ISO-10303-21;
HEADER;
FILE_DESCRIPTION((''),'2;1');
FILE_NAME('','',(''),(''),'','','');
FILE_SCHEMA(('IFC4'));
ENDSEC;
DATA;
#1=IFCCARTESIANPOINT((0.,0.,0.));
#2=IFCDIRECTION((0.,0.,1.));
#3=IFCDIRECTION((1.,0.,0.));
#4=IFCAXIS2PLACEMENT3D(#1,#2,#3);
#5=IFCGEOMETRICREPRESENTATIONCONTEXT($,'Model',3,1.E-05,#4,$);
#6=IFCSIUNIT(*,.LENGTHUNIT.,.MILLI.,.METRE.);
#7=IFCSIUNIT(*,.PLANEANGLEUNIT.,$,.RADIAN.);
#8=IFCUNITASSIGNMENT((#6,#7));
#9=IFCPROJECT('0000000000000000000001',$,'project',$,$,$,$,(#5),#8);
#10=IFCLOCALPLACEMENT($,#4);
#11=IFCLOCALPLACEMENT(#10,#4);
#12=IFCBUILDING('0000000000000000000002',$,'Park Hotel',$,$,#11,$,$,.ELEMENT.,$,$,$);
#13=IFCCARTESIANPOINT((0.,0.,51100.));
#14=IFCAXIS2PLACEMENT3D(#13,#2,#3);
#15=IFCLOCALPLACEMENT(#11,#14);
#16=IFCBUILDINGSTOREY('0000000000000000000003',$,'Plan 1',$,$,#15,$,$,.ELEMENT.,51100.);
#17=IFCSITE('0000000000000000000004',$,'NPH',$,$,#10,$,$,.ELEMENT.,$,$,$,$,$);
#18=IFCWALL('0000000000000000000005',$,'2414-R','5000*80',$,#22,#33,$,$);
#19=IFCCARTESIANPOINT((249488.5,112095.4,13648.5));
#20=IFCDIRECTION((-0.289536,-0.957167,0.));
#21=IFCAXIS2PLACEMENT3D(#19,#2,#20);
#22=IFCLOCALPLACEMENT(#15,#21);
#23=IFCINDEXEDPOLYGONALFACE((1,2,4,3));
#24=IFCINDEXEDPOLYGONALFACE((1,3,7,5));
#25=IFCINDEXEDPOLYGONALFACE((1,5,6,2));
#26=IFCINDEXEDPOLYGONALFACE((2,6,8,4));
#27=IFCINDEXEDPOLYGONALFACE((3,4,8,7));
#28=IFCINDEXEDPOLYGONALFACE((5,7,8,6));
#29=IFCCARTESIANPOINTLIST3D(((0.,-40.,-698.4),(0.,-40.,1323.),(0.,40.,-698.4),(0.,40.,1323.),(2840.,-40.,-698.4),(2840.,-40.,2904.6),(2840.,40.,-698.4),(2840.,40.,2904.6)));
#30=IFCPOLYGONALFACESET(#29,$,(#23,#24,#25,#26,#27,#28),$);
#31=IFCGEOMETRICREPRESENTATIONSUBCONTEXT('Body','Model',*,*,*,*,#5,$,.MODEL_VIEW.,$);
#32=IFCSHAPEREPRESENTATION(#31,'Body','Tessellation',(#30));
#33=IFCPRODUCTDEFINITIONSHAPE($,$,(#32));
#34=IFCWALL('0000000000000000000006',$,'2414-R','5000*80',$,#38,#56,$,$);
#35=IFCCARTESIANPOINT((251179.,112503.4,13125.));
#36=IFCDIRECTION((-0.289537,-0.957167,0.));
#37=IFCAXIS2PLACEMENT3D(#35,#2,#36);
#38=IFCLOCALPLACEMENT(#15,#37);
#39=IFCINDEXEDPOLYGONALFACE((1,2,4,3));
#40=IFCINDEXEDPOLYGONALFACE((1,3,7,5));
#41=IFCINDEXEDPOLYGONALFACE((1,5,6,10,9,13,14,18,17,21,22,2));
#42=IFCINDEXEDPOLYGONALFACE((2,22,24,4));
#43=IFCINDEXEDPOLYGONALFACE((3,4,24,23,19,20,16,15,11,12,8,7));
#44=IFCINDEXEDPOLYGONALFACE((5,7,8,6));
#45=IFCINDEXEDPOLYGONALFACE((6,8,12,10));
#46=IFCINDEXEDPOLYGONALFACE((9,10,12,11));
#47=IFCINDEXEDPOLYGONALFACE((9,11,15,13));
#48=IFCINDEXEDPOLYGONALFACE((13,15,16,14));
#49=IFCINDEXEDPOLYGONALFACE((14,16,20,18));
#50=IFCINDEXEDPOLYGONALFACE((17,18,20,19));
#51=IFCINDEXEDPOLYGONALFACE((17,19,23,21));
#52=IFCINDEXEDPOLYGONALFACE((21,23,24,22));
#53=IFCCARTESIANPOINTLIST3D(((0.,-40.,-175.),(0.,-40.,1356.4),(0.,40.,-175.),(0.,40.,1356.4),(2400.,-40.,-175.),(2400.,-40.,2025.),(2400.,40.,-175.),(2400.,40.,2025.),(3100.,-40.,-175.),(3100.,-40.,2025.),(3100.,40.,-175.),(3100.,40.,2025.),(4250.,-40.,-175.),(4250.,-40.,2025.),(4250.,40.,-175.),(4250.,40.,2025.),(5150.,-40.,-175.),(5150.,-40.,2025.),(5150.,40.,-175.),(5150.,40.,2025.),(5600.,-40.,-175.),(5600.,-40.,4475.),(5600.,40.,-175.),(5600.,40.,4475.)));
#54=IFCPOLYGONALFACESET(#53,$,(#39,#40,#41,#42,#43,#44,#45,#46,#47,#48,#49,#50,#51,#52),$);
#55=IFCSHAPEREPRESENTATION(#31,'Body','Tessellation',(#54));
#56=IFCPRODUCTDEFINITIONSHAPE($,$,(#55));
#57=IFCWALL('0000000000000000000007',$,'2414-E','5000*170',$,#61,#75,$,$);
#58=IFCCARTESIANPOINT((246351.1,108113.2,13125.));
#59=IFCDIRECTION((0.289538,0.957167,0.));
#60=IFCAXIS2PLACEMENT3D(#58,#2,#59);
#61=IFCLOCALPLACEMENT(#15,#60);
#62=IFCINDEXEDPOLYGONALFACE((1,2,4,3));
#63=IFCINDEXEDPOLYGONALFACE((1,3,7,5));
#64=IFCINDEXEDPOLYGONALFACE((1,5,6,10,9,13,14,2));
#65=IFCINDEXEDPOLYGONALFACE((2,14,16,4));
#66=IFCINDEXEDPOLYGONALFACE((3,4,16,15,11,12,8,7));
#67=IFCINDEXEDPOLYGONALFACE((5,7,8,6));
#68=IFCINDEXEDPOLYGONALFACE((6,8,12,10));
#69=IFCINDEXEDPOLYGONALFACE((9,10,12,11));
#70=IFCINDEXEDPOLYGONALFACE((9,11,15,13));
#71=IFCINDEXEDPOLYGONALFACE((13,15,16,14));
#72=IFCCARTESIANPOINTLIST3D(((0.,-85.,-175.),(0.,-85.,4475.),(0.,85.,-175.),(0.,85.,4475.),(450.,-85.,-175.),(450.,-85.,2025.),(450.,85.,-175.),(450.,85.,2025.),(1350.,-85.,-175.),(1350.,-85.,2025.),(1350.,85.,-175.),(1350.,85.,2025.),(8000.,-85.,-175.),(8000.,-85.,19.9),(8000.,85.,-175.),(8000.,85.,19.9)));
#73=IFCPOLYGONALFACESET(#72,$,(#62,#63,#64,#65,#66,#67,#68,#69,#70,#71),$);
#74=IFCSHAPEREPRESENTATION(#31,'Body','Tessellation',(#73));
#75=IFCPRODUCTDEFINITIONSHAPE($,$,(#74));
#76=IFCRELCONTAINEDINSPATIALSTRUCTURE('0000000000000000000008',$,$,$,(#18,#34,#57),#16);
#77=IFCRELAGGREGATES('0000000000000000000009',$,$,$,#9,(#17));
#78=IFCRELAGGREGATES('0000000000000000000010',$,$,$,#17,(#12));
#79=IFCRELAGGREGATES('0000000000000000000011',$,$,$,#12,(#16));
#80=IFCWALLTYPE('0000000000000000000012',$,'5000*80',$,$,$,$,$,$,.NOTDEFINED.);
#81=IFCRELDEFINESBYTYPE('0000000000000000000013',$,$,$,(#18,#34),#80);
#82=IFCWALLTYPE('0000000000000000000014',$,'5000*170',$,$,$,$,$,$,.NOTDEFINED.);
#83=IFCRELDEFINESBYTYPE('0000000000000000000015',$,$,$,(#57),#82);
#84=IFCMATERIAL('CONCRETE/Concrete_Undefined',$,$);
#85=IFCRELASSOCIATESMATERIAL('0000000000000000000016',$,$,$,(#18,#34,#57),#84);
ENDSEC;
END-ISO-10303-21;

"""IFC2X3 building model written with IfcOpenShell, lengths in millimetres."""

from ifc_helpers import new_model, si_unit, frame, frame_2d, origin_with_axes, place, context, subcontext, project, spatial, rectangle, extrude, boolean, clip, halfspace, material, type_object, element, save


model = new_model("IFC2X3")

# Units and contexts
model_context = context("Model", 3, precision=1e-05, world=origin_with_axes())
body_context = subcontext(model_context, "Body", "Model", "MODEL_VIEW")
ifc_project = project(units=[si_unit("LENGTHUNIT", "METRE", prefix="MILLI"), si_unit("PLANEANGLEUNIT", "RADIAN")], contexts=[model_context])

# Site, building, storey
site_placement = place(None, origin_with_axes())
site = spatial("IfcSite", under=ifc_project, at=site_placement, Name="NPH", CompositionType="ELEMENT")
building_placement = place(site_placement, origin_with_axes())
building = spatial("IfcBuilding", under=site, at=building_placement, Name="Park Hotel", CompositionType="ELEMENT")
storey_placement = place(building_placement, frame((0.0, 0.0, 51100.0), z_axis=(0.0, 0.0, 1.0), x_axis=(1.0, 0.0, 0.0)))
storey = spatial("IfcBuildingStorey", under=building, at=storey_placement, Name="Plan 1", CompositionType="ELEMENT", Elevation=51100.0)

# Walls
ifc_material_1 = material(Name="CONCRETE/Concrete_Undefined")
wall_type_1 = type_object("IfcWallType", Name="5000*80", PredefinedType="NOTDEFINED")
wall_1_placement = place(storey_placement, frame((249488.5, 112095.4, 13648.5), z_axis=(0.0, 0.0, 1.0), x_axis=(-0.289536, -0.957167, 0.0)))
element("IfcWall", 1, at=wall_1_placement, inside=storey, type_object=wall_type_1, material=ifc_material_1, Name="2414-R", Description="5000*80", context=body_context, shape_type="Clipping", body=[
    clip(extrude(rectangle(XDim=2840.0, YDim=80.0, at=frame_2d((0.0, 1420.0), x_axis=(0.0, -1.0))), frame((0.0, 0.0, -698.4), z_axis=(0.0, 0.0, 1.0), x_axis=(0.0, -1.0, 0.0)), (0.0, 0.0, 1.0), 5000.0), halfspace(frame((-3630.0, 40.0, -698.4), z_axis=(-0.486531, 0.000001, 0.873663), x_axis=(0.873663, 0.0, 0.486531)), False)),
])
wall_2_placement = place(storey_placement, frame((251179.0, 112503.4, 13125.0), z_axis=(0.0, 0.0, 1.0), x_axis=(-0.289537, -0.957167, 0.0)))
element("IfcWall", 2, at=wall_2_placement, inside=storey, type_object=wall_type_1, material=ifc_material_1, Name="2414-R", Description="5000*80", context=body_context, shape_type="CSG", body=[
    boolean("DIFFERENCE", boolean("DIFFERENCE", boolean("DIFFERENCE", extrude(rectangle(XDim=5600.0, YDim=80.0, at=frame_2d((0.0, 2800.0), x_axis=(0.0, -1.0))), frame((0.0, 0.0, -175.0), z_axis=(0.0, 0.0, 1.0), x_axis=(0.0, -1.0, 0.0)), (0.0, 0.0, 1.0), 5000.0), extrude(rectangle(XDim=700.0, YDim=150.0, at=frame_2d((0.0, 350.0), x_axis=(0.0, -1.0))), frame((3100.0, -34.8, -175.0), z_axis=(0.0, 0.0, 1.0), x_axis=(0.000006, 1.0, 0.0)), (0.0, 0.0, 1.0), 2200.0)), extrude(rectangle(XDim=900.0, YDim=150.0, at=frame_2d((0.0, 450.0), x_axis=(0.0, -1.0))), frame((5150.0, -34.8, -175.0), z_axis=(0.0, 0.0, 1.0), x_axis=(0.000005, 1.0, 0.0)), (0.0, 0.0, 1.0), 2200.0)), halfspace(frame((-2750.0, 40.0, -175.0), z_axis=(-0.486531, 0.000001, 0.873663), x_axis=(0.873663, 0.0, 0.486531)), False)),
])
wall_type_2 = type_object("IfcWallType", Name="5000*170", PredefinedType="NOTDEFINED")
wall_3_placement = place(storey_placement, frame((246351.1, 108113.2, 13125.0), z_axis=(0.0, 0.0, 1.0), x_axis=(0.289538, 0.957167, 0.0)))
element("IfcWall", 3, at=wall_3_placement, inside=storey, type_object=wall_type_2, material=ifc_material_1, Name="2414-E", Description="5000*170", context=body_context, shape_type="CSG", body=[
    boolean("DIFFERENCE", boolean("DIFFERENCE", extrude(rectangle(XDim=8000.0, YDim=170.0, at=frame_2d((0.0, 4000.0), x_axis=(0.0, -1.0))), frame((0.0, 0.0, -175.0), z_axis=(0.0, 0.0, 1.0), x_axis=(0.0, -1.0, 0.0)), (0.0, 0.0, 1.0), 5000.0), extrude(rectangle(XDim=900.0, YDim=200.0, at=frame_2d((0.0, 450.0), x_axis=(0.0, -1.0))), frame((450.0, -15.0, -175.0), z_axis=(0.0, 0.0, 1.0), x_axis=(0.000001, -1.0, 0.0)), (0.0, 0.0, 1.0), 2200.0)), halfspace(frame((3322.0, 85.0, 2625.0), z_axis=(0.486531, 0.0, 0.873663), x_axis=(0.873663, 0.0, -0.486531)), False)),
])

save(model, "model.ifc")
